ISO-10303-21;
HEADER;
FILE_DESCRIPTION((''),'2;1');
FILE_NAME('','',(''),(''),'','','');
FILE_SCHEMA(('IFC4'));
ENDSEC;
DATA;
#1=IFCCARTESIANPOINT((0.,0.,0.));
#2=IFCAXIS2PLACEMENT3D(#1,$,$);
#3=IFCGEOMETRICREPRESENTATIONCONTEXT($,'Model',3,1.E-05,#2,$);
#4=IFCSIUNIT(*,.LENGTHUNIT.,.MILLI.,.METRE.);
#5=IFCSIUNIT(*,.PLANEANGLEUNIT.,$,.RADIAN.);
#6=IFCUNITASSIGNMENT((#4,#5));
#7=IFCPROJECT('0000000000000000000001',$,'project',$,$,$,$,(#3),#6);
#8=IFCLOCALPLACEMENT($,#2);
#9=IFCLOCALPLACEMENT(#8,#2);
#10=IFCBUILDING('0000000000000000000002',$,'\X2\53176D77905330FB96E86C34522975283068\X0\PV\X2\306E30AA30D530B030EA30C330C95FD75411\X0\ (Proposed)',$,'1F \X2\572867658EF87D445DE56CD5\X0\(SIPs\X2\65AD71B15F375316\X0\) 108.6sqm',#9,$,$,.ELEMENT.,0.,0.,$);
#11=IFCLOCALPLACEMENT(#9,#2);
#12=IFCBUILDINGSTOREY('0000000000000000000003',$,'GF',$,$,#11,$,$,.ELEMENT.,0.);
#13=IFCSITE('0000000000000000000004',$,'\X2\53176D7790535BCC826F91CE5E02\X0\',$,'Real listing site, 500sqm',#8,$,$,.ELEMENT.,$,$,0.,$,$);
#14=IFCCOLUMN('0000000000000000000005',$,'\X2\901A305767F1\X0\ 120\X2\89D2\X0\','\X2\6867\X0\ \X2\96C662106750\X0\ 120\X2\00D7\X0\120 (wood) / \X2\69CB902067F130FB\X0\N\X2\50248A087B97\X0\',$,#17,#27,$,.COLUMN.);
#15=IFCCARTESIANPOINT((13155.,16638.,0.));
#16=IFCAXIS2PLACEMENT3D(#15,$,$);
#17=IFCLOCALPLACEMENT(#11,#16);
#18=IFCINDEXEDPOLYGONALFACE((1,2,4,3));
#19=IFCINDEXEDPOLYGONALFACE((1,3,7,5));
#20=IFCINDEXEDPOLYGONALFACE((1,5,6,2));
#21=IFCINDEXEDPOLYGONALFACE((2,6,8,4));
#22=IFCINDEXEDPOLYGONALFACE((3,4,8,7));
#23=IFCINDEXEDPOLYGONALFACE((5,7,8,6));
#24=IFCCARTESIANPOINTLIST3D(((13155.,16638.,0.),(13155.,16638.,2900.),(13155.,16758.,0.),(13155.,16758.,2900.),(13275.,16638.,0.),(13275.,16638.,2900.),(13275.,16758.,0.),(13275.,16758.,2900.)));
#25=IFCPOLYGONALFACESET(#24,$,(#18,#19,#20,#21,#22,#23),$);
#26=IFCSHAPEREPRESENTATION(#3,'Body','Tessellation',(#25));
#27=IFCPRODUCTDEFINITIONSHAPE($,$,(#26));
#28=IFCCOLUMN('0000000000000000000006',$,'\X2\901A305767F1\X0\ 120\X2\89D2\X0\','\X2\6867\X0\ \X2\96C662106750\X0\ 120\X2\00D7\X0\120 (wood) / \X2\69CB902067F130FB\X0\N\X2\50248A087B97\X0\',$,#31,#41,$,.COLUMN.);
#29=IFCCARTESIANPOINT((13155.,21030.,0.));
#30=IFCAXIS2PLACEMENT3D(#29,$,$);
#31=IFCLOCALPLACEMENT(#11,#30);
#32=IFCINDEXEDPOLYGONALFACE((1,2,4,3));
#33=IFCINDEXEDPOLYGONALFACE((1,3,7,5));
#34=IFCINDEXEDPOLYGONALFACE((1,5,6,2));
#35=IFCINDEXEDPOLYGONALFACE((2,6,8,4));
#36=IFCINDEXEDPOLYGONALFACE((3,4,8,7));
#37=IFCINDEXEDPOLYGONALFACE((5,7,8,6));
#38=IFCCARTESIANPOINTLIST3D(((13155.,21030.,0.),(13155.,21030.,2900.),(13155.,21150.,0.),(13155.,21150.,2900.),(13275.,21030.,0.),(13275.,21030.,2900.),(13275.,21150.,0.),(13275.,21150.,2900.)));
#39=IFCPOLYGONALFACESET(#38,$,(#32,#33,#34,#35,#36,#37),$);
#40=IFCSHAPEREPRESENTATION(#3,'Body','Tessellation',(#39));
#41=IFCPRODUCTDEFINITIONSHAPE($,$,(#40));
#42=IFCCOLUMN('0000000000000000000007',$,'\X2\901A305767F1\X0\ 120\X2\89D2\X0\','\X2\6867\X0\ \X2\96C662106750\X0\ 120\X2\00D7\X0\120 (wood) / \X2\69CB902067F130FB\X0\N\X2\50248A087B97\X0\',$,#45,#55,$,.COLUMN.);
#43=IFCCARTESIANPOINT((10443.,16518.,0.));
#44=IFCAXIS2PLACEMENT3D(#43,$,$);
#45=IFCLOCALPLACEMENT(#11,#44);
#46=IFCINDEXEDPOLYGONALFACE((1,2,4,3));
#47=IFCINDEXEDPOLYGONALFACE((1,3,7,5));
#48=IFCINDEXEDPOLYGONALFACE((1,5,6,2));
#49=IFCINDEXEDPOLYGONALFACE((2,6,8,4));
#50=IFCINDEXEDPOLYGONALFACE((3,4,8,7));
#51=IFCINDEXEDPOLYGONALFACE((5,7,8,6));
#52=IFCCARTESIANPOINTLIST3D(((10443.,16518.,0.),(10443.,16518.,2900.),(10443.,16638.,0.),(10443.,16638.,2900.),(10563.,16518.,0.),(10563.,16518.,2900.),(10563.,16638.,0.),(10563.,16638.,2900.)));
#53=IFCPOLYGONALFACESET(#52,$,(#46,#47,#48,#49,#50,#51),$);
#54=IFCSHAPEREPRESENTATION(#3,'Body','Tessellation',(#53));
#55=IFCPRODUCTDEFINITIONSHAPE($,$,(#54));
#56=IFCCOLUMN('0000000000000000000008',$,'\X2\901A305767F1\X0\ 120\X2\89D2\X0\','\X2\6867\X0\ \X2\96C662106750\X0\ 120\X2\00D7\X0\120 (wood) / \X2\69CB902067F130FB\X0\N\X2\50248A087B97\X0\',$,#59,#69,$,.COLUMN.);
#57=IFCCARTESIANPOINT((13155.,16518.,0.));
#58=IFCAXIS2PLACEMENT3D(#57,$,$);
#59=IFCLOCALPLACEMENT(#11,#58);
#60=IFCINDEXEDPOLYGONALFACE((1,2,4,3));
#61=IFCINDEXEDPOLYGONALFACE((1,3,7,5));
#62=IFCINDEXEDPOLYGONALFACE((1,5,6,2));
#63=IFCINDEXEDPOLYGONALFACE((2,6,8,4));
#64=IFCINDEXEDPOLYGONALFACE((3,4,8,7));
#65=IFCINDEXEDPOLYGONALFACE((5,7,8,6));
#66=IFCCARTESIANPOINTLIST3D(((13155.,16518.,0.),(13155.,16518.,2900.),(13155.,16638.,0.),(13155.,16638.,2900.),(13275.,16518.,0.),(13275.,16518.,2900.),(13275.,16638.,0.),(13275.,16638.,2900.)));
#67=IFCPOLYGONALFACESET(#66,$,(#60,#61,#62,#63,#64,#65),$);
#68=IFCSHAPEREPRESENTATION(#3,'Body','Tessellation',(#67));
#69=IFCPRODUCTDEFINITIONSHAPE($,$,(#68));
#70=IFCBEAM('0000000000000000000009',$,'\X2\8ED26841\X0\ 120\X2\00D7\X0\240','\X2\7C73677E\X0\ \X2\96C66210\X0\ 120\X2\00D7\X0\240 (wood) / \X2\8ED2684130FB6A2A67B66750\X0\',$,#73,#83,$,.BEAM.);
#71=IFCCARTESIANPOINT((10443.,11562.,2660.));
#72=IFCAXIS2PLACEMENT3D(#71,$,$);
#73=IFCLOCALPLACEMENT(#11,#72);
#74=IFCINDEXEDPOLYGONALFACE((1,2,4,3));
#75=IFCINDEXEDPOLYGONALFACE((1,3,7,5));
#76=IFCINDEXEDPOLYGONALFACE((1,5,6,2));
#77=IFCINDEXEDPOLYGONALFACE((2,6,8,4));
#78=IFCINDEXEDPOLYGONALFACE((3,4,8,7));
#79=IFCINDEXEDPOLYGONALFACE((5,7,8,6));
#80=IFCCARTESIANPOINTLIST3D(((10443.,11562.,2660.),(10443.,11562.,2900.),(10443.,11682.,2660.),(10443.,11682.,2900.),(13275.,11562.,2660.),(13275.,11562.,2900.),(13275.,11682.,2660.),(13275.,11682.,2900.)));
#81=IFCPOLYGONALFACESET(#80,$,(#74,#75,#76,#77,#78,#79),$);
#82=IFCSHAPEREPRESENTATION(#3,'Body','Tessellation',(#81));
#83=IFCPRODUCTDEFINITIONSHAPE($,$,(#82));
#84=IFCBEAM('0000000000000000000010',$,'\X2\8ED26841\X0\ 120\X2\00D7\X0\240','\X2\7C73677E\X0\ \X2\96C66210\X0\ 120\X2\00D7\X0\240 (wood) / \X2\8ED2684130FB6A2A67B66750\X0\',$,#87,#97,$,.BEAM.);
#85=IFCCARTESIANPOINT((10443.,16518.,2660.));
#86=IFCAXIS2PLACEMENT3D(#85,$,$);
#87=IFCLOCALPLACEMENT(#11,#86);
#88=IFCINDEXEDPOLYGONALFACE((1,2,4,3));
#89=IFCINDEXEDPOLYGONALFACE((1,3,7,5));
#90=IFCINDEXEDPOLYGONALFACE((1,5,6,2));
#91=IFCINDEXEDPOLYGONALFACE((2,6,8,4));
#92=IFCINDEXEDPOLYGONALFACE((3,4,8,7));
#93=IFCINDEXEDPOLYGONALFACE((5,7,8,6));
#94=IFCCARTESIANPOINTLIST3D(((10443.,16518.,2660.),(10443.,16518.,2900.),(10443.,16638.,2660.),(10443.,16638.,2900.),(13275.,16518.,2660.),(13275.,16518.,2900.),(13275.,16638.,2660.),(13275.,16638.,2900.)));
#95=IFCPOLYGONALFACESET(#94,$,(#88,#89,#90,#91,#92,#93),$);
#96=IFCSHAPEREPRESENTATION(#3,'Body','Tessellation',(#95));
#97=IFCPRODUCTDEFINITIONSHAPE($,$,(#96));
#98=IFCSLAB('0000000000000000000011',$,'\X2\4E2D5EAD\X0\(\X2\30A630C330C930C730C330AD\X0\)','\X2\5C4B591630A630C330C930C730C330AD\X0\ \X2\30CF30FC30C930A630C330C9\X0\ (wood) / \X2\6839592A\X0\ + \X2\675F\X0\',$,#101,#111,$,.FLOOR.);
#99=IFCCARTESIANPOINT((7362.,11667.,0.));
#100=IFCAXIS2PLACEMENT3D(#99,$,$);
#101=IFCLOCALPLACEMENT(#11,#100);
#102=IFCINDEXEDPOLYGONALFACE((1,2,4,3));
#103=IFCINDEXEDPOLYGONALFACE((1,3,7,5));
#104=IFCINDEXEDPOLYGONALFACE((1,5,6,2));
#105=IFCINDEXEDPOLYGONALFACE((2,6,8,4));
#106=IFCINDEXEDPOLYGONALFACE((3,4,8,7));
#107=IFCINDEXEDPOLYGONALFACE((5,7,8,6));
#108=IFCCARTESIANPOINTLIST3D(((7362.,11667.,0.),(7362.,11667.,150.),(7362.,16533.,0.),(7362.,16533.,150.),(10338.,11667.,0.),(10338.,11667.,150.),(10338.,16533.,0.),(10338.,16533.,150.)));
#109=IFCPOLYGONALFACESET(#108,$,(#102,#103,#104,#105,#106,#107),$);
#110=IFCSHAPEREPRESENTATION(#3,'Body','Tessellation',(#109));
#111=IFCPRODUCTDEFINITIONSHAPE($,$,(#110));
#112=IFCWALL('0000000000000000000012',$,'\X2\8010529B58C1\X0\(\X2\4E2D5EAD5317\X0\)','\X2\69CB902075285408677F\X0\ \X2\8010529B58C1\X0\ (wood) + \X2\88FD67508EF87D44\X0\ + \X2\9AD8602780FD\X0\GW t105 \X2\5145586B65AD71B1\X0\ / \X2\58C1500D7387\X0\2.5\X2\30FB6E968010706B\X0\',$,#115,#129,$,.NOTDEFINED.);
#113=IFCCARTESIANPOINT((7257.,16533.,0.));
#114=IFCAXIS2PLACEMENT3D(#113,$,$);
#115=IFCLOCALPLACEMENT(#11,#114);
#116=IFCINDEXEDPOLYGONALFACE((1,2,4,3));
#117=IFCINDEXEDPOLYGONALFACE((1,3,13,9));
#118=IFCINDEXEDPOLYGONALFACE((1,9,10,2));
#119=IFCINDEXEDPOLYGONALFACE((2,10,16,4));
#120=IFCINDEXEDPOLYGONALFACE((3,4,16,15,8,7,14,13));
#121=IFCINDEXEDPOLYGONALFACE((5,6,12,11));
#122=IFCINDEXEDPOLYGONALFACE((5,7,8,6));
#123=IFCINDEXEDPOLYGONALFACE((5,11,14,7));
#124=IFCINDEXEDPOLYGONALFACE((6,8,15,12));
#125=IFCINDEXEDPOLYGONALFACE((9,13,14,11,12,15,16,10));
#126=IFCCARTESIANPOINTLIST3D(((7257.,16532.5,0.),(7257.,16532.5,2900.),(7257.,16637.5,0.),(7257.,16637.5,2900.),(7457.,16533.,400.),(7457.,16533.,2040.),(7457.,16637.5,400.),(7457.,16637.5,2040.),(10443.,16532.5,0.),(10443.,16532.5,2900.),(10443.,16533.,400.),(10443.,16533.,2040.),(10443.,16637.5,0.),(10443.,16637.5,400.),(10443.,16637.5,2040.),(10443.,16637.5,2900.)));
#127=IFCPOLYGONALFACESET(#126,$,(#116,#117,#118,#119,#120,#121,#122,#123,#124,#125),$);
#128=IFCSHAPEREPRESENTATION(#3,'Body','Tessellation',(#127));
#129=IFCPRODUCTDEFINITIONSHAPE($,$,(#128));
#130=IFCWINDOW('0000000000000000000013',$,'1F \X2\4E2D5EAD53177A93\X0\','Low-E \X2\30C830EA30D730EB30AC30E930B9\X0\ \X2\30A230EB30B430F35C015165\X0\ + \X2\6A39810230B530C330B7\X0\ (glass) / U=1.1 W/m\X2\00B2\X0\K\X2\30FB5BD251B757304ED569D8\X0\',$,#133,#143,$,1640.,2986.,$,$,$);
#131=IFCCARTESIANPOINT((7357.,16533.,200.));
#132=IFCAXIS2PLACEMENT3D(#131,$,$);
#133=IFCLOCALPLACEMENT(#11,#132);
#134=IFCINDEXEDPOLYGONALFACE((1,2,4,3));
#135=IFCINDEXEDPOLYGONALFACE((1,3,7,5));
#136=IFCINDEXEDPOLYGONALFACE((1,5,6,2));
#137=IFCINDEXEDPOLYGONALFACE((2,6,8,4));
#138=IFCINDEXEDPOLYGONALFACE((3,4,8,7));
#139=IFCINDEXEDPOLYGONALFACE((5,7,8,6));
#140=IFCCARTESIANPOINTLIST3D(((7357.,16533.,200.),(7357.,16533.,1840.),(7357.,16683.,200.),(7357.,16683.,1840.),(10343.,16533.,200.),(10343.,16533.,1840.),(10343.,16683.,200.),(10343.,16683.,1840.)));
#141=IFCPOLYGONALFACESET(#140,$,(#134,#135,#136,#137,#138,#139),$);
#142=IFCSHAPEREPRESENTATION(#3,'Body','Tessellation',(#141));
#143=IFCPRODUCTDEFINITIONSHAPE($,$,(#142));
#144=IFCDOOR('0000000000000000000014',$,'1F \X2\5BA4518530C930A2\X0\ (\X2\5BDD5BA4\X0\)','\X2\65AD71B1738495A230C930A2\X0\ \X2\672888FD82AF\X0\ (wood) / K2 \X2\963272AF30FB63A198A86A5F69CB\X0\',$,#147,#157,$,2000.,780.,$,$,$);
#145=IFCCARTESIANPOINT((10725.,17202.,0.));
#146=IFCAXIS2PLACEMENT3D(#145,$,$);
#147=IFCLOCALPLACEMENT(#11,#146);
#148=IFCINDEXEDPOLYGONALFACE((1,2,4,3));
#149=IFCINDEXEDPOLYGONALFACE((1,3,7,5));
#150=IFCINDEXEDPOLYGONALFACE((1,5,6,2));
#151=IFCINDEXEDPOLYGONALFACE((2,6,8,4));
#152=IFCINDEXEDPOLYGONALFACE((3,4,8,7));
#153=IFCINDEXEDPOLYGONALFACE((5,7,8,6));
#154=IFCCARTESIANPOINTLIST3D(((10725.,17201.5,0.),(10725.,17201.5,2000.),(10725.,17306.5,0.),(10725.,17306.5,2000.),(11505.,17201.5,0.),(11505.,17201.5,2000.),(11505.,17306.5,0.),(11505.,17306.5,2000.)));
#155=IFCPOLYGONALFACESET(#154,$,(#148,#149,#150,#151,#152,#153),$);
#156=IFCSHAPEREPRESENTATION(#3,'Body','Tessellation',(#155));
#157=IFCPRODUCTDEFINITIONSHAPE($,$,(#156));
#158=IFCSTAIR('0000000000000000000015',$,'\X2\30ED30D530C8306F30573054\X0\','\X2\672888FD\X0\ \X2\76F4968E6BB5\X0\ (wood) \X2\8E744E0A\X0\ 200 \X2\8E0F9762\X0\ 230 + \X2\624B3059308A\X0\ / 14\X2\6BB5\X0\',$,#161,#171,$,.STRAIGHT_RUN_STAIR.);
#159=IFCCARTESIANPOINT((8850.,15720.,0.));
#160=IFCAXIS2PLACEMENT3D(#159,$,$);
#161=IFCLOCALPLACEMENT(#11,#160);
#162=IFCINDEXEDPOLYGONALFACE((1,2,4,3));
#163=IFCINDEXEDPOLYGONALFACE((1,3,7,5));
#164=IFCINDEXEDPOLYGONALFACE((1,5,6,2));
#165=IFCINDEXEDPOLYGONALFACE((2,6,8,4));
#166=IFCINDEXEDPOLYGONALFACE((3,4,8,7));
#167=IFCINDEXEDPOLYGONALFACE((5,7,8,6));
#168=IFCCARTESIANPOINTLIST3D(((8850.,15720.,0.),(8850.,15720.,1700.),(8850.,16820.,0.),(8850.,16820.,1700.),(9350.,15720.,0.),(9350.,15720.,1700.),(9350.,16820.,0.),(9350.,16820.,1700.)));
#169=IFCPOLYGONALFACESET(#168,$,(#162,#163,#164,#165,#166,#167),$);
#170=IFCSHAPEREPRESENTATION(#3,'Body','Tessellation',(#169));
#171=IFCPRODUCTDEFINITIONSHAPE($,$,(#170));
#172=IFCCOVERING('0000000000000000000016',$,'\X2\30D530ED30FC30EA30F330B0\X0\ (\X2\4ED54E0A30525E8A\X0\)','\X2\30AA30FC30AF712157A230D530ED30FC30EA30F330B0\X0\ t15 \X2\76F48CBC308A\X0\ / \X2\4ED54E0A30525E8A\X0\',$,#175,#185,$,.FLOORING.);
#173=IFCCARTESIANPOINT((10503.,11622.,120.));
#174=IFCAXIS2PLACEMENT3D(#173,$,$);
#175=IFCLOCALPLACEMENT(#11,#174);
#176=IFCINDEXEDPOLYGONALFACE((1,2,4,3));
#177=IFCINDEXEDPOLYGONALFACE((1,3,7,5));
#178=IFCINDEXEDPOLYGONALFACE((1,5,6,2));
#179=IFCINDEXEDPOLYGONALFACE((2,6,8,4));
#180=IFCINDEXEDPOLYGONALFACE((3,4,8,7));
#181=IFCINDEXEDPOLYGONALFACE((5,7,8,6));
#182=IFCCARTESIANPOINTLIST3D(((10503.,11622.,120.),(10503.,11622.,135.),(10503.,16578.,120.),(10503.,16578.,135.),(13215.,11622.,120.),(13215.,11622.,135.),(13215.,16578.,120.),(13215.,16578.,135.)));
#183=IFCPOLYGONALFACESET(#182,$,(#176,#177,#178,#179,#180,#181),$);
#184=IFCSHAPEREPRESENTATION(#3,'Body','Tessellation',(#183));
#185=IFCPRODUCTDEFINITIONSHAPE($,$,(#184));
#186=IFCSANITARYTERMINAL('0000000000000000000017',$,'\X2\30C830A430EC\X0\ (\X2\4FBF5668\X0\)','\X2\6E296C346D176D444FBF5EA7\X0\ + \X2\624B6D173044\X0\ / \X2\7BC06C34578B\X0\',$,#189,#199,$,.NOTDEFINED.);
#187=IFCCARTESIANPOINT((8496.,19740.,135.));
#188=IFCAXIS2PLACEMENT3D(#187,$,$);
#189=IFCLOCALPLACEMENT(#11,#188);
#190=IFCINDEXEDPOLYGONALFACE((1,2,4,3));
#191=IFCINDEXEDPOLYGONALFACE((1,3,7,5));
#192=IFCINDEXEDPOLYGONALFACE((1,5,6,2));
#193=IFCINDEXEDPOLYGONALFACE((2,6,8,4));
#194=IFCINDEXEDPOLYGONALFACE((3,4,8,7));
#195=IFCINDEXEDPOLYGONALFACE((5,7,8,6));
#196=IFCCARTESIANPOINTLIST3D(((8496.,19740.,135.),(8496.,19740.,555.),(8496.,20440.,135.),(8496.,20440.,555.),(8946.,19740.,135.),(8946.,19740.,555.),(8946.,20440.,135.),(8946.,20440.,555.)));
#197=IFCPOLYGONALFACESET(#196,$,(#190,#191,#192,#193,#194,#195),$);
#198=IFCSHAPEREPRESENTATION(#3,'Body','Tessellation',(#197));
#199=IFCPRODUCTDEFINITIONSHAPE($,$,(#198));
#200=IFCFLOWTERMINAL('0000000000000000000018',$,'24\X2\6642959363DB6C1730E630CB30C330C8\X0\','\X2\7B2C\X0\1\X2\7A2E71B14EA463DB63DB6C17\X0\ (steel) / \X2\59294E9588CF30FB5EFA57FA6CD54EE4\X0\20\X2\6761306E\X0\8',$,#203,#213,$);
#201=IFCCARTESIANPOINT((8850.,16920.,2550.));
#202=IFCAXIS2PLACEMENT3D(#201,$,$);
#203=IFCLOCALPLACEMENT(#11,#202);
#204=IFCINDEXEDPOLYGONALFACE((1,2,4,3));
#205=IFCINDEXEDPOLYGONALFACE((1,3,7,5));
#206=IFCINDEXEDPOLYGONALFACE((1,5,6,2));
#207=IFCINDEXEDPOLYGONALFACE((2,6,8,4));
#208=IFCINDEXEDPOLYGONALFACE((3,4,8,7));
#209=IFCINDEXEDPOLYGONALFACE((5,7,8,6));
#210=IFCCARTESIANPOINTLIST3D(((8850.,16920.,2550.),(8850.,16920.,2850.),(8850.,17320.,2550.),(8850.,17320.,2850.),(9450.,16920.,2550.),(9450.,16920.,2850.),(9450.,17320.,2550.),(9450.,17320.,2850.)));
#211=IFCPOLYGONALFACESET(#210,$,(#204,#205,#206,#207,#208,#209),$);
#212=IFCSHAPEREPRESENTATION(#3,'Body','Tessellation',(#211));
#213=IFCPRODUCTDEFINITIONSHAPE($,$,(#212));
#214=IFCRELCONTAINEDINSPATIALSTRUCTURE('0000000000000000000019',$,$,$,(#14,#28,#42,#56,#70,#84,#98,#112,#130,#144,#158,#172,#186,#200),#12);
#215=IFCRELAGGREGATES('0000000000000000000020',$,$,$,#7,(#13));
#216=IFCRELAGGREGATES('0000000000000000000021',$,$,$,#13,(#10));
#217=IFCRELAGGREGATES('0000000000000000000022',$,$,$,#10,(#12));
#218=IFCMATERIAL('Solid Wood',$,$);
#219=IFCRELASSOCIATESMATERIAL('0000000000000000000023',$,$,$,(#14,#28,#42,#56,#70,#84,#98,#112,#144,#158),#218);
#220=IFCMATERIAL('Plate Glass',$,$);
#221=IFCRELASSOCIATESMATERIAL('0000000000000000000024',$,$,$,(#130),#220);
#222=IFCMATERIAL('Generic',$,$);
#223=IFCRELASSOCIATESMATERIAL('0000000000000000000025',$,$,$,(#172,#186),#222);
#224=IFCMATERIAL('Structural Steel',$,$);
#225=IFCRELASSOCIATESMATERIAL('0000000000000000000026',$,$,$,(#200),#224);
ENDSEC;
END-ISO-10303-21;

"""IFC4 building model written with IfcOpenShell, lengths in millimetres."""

from ifc_helpers import new_model, si_unit, frame, frame_2d, origin, place, context, project, spatial, rectangle, extrude, material, element, fill, save


model = new_model("IFC4")

# Units and contexts
model_context = context("Model", 3, precision=1e-05, world=origin())
ifc_project = project(units=[si_unit("LENGTHUNIT", "METRE", prefix="MILLI"), si_unit("PLANEANGLEUNIT", "RADIAN")], contexts=[model_context])

# Site, building, storey
site_placement = place(None, origin())
site = spatial("IfcSite", under=ifc_project, at=site_placement, Name="北海道富良野市", ObjectType="Real listing site, 500sqm", CompositionType="ELEMENT", RefElevation=0.0)
building_placement = place(site_placement, origin())
building = spatial("IfcBuilding", under=site, at=building_placement, Name="北海道・雨水利用とPVのオフグリッド志向 (Proposed)", ObjectType="1F 在来軸組工法(SIPs断熱強化) 108.6sqm", CompositionType="ELEMENT", ElevationOfRefHeight=0.0, ElevationOfTerrain=0.0)
storey_placement = place(building_placement, origin())
storey = spatial("IfcBuildingStorey", under=building, at=storey_placement, Name="GF", CompositionType="ELEMENT", Elevation=0.0)

# Columns
ifc_material_1 = material(Name="Solid Wood")
column_1_placement = place(storey_placement, frame((13155.0, 16638.0, 0.0)))
element("IfcColumn", 1, at=column_1_placement, inside=storey, material=ifc_material_1, Name="通し柱 120角", Description="桧 集成材 120×120 (wood) / 構造柱・N値計算", PredefinedType="COLUMN", context=model_context, shape_type="SweptSolid", body=[
    extrude(rectangle(XDim=120.0, YDim=120.0, at=frame_2d((60.0, 60.0))), frame((13155.0, 16638.0, 0.0)), (0.0, 0.0, 1.0), 2900.0),
])
column_2_placement = place(storey_placement, frame((13155.0, 21030.0, 0.0)))
element("IfcColumn", 2, at=column_2_placement, inside=storey, material=ifc_material_1, Name="通し柱 120角", Description="桧 集成材 120×120 (wood) / 構造柱・N値計算", PredefinedType="COLUMN", context=model_context, shape_type="SweptSolid", body=[
    extrude(rectangle(XDim=120.0, YDim=120.0, at=frame_2d((60.0, 60.0))), frame((13155.0, 21030.0, 0.0)), (0.0, 0.0, 1.0), 2900.0),
])
column_3_placement = place(storey_placement, frame((10443.0, 16518.0, 0.0)))
element("IfcColumn", 3, at=column_3_placement, inside=storey, material=ifc_material_1, Name="通し柱 120角", Description="桧 集成材 120×120 (wood) / 構造柱・N値計算", PredefinedType="COLUMN", context=model_context, shape_type="SweptSolid", body=[
    extrude(rectangle(XDim=120.0, YDim=120.0, at=frame_2d((60.0, 60.0))), frame((10443.0, 16518.0, 0.0)), (0.0, 0.0, 1.0), 2900.0),
])
column_4_placement = place(storey_placement, frame((13155.0, 16518.0, 0.0)))
element("IfcColumn", 4, at=column_4_placement, inside=storey, material=ifc_material_1, Name="通し柱 120角", Description="桧 集成材 120×120 (wood) / 構造柱・N値計算", PredefinedType="COLUMN", context=model_context, shape_type="SweptSolid", body=[
    extrude(rectangle(XDim=120.0, YDim=120.0, at=frame_2d((60.0, 60.0))), frame((13155.0, 16518.0, 0.0)), (0.0, 0.0, 1.0), 2900.0),
])

# Beams
beam_1_placement = place(storey_placement, frame((10443.0, 11562.0, 2660.0)))
element("IfcBeam", 5, at=beam_1_placement, inside=storey, material=ifc_material_1, Name="軒桁 120×240", Description="米松 集成 120×240 (wood) / 軒桁・横架材", PredefinedType="BEAM", context=model_context, shape_type="SweptSolid", body=[
    extrude(rectangle(XDim=2832.0, YDim=120.0, at=frame_2d((1416.0, 60.0))), frame((10443.0, 11562.0, 2660.0)), (0.0, 0.0, 1.0), 240.0),
])
beam_2_placement = place(storey_placement, frame((10443.0, 16518.0, 2660.0)))
element("IfcBeam", 6, at=beam_2_placement, inside=storey, material=ifc_material_1, Name="軒桁 120×240", Description="米松 集成 120×240 (wood) / 軒桁・横架材", PredefinedType="BEAM", context=model_context, shape_type="SweptSolid", body=[
    extrude(rectangle(XDim=2832.0, YDim=120.0, at=frame_2d((1416.0, 60.0))), frame((10443.0, 16518.0, 2660.0)), (0.0, 0.0, 1.0), 240.0),
])

# Slab
slab_placement = place(storey_placement, frame((7362.0, 11667.0, 0.0)))
element("IfcSlab", 7, at=slab_placement, inside=storey, material=ifc_material_1, Name="中庭(ウッドデッキ)", Description="屋外ウッドデッキ ハードウッド (wood) / 根太 + 束", PredefinedType="FLOOR", context=model_context, shape_type="SweptSolid", body=[
    extrude(rectangle(XDim=2976.0, YDim=4866.0, at=frame_2d((1488.0, 2433.0))), frame((7362.0, 11667.0, 0.0)), (0.0, 0.0, 1.0), 150.0),
])

# Wall, opening, window
wall_1_placement = place(storey_placement, frame((7257.0, 16533.0, 0.0)))
wall_1 = element("IfcWall", 8, at=wall_1_placement, inside=storey, material=ifc_material_1, Name="耐力壁(中庭北)", Description="構造用合板 耐力壁 (wood) + 製材軸組 + 高性能GW t105 充填断熱 / 壁倍率2.5・準耐火", PredefinedType="NOTDEFINED", context=model_context, shape_type="SweptSolid", body=[
    extrude(rectangle(XDim=3186.0, YDim=105.0, at=frame_2d((1593.0, 52.0))), frame((7257.0, 16533.0, 0.0)), (0.0, 0.0, 1.0), 2900.0),
])
opening_placement = place(storey_placement, frame((7357.0, 16533.0, 200.0)))
opening = element("IfcOpeningElement", 9, at=opening_placement, cuts=wall_1, PredefinedType="NOTDEFINED", context=model_context, shape_type="SweptSolid", body=[
    extrude(rectangle(XDim=2986.0, YDim=150.0, at=frame_2d((1493.0, 75.0))), frame((7357.0, 16533.0, 200.0)), (0.0, 0.0, 1.0), 1640.0),
])
ifc_material_2 = material(Name="Plate Glass")
window_placement = place(storey_placement, frame((7357.0, 16533.0, 200.0)))
window = element("IfcWindow", 10, at=window_placement, inside=storey, material=ifc_material_2, Name="1F 中庭北窓", Description="Low-E トリプルガラス アルゴン封入 + 樹脂サッシ (glass) / U=1.1 W/m²K・寒冷地仕様", OverallHeight=1640.0, OverallWidth=2986.0, context=model_context, shape_type="SweptSolid", body=[
    extrude(rectangle(XDim=2986.0, YDim=150.0, at=frame_2d((1493.0, 75.0))), frame((7357.0, 16533.0, 200.0)), (0.0, 0.0, 1.0), 1640.0),
])
fill(opening, window)

# Door
door_placement = place(storey_placement, frame((10725.0, 17202.0, 0.0)))
element("IfcDoor", 11, at=door_placement, inside=storey, material=ifc_material_1, Name="1F 室内ドア (寝室)", Description="断熱玄関ドア 木製芯 (wood) / K2 防犯・採風機構", OverallHeight=2000.0, OverallWidth=780.0, context=model_context, shape_type="SweptSolid", body=[
    extrude(rectangle(XDim=780.0, YDim=105.0, at=frame_2d((390.0, 52.0))), frame((10725.0, 17202.0, 0.0)), (0.0, 0.0, 1.0), 2000.0),
])

# Stair
stair_placement = place(storey_placement, frame((8850.0, 15720.0, 0.0)))
element("IfcStair", 12, at=stair_placement, inside=storey, material=ifc_material_1, Name="ロフトはしご", Description="木製 直階段 (wood) 蹴上 200 踏面 230 + 手すり / 14段", PredefinedType="STRAIGHT_RUN_STAIR", context=model_context, shape_type="SweptSolid", body=[
    extrude(rectangle(XDim=500.0, YDim=1100.0, at=frame_2d((250.0, 550.0))), frame((8850.0, 15720.0, 0.0)), (0.0, 0.0, 1.0), 1700.0),
])

# Covering
ifc_material_3 = material(Name="Generic")
covering_placement = place(storey_placement, frame((10503.0, 11622.0, 120.0)))
element("IfcCovering", 13, at=covering_placement, inside=storey, material=ifc_material_3, Name="フローリング (仕上げ床)", Description="オーク無垢フローリング t15 直貼り / 仕上げ床", PredefinedType="FLOORING", context=model_context, shape_type="SweptSolid", body=[
    extrude(rectangle(XDim=2712.0, YDim=4956.0, at=frame_2d((1356.0, 2478.0))), frame((10503.0, 11622.0, 120.0)), (0.0, 0.0, 1.0), 15.0),
])

# Sanitary terminal
sanitary_terminal_placement = place(storey_placement, frame((8496.0, 19740.0, 135.0)))
element("IfcSanitaryTerminal", 14, at=sanitary_terminal_placement, inside=storey, material=ifc_material_3, Name="トイレ (便器)", Description="温水洗浄便座 + 手洗い / 節水型", PredefinedType="NOTDEFINED", context=model_context, shape_type="SweptSolid", body=[
    extrude(rectangle(XDim=450.0, YDim=700.0, at=frame_2d((225.0, 350.0))), frame((8496.0, 19740.0, 135.0)), (0.0, 0.0, 1.0), 420.0),
])

# Flow terminal
ifc_material_4 = material(Name="Structural Steel")
flow_terminal_placement = place(storey_placement, frame((8850.0, 16920.0, 2550.0)))
element("IfcFlowTerminal", 15, at=flow_terminal_placement, inside=storey, material=ifc_material_4, Name="24時間換気ユニット", Description="第1種熱交換換気 (steel) / 天井裏・建基法令20条の8", context=model_context, shape_type="SweptSolid", body=[
    extrude(rectangle(XDim=600.0, YDim=400.0, at=frame_2d((300.0, 200.0))), frame((8850.0, 16920.0, 2550.0)), (0.0, 0.0, 1.0), 300.0),
])

save(model, "model.ifc")
